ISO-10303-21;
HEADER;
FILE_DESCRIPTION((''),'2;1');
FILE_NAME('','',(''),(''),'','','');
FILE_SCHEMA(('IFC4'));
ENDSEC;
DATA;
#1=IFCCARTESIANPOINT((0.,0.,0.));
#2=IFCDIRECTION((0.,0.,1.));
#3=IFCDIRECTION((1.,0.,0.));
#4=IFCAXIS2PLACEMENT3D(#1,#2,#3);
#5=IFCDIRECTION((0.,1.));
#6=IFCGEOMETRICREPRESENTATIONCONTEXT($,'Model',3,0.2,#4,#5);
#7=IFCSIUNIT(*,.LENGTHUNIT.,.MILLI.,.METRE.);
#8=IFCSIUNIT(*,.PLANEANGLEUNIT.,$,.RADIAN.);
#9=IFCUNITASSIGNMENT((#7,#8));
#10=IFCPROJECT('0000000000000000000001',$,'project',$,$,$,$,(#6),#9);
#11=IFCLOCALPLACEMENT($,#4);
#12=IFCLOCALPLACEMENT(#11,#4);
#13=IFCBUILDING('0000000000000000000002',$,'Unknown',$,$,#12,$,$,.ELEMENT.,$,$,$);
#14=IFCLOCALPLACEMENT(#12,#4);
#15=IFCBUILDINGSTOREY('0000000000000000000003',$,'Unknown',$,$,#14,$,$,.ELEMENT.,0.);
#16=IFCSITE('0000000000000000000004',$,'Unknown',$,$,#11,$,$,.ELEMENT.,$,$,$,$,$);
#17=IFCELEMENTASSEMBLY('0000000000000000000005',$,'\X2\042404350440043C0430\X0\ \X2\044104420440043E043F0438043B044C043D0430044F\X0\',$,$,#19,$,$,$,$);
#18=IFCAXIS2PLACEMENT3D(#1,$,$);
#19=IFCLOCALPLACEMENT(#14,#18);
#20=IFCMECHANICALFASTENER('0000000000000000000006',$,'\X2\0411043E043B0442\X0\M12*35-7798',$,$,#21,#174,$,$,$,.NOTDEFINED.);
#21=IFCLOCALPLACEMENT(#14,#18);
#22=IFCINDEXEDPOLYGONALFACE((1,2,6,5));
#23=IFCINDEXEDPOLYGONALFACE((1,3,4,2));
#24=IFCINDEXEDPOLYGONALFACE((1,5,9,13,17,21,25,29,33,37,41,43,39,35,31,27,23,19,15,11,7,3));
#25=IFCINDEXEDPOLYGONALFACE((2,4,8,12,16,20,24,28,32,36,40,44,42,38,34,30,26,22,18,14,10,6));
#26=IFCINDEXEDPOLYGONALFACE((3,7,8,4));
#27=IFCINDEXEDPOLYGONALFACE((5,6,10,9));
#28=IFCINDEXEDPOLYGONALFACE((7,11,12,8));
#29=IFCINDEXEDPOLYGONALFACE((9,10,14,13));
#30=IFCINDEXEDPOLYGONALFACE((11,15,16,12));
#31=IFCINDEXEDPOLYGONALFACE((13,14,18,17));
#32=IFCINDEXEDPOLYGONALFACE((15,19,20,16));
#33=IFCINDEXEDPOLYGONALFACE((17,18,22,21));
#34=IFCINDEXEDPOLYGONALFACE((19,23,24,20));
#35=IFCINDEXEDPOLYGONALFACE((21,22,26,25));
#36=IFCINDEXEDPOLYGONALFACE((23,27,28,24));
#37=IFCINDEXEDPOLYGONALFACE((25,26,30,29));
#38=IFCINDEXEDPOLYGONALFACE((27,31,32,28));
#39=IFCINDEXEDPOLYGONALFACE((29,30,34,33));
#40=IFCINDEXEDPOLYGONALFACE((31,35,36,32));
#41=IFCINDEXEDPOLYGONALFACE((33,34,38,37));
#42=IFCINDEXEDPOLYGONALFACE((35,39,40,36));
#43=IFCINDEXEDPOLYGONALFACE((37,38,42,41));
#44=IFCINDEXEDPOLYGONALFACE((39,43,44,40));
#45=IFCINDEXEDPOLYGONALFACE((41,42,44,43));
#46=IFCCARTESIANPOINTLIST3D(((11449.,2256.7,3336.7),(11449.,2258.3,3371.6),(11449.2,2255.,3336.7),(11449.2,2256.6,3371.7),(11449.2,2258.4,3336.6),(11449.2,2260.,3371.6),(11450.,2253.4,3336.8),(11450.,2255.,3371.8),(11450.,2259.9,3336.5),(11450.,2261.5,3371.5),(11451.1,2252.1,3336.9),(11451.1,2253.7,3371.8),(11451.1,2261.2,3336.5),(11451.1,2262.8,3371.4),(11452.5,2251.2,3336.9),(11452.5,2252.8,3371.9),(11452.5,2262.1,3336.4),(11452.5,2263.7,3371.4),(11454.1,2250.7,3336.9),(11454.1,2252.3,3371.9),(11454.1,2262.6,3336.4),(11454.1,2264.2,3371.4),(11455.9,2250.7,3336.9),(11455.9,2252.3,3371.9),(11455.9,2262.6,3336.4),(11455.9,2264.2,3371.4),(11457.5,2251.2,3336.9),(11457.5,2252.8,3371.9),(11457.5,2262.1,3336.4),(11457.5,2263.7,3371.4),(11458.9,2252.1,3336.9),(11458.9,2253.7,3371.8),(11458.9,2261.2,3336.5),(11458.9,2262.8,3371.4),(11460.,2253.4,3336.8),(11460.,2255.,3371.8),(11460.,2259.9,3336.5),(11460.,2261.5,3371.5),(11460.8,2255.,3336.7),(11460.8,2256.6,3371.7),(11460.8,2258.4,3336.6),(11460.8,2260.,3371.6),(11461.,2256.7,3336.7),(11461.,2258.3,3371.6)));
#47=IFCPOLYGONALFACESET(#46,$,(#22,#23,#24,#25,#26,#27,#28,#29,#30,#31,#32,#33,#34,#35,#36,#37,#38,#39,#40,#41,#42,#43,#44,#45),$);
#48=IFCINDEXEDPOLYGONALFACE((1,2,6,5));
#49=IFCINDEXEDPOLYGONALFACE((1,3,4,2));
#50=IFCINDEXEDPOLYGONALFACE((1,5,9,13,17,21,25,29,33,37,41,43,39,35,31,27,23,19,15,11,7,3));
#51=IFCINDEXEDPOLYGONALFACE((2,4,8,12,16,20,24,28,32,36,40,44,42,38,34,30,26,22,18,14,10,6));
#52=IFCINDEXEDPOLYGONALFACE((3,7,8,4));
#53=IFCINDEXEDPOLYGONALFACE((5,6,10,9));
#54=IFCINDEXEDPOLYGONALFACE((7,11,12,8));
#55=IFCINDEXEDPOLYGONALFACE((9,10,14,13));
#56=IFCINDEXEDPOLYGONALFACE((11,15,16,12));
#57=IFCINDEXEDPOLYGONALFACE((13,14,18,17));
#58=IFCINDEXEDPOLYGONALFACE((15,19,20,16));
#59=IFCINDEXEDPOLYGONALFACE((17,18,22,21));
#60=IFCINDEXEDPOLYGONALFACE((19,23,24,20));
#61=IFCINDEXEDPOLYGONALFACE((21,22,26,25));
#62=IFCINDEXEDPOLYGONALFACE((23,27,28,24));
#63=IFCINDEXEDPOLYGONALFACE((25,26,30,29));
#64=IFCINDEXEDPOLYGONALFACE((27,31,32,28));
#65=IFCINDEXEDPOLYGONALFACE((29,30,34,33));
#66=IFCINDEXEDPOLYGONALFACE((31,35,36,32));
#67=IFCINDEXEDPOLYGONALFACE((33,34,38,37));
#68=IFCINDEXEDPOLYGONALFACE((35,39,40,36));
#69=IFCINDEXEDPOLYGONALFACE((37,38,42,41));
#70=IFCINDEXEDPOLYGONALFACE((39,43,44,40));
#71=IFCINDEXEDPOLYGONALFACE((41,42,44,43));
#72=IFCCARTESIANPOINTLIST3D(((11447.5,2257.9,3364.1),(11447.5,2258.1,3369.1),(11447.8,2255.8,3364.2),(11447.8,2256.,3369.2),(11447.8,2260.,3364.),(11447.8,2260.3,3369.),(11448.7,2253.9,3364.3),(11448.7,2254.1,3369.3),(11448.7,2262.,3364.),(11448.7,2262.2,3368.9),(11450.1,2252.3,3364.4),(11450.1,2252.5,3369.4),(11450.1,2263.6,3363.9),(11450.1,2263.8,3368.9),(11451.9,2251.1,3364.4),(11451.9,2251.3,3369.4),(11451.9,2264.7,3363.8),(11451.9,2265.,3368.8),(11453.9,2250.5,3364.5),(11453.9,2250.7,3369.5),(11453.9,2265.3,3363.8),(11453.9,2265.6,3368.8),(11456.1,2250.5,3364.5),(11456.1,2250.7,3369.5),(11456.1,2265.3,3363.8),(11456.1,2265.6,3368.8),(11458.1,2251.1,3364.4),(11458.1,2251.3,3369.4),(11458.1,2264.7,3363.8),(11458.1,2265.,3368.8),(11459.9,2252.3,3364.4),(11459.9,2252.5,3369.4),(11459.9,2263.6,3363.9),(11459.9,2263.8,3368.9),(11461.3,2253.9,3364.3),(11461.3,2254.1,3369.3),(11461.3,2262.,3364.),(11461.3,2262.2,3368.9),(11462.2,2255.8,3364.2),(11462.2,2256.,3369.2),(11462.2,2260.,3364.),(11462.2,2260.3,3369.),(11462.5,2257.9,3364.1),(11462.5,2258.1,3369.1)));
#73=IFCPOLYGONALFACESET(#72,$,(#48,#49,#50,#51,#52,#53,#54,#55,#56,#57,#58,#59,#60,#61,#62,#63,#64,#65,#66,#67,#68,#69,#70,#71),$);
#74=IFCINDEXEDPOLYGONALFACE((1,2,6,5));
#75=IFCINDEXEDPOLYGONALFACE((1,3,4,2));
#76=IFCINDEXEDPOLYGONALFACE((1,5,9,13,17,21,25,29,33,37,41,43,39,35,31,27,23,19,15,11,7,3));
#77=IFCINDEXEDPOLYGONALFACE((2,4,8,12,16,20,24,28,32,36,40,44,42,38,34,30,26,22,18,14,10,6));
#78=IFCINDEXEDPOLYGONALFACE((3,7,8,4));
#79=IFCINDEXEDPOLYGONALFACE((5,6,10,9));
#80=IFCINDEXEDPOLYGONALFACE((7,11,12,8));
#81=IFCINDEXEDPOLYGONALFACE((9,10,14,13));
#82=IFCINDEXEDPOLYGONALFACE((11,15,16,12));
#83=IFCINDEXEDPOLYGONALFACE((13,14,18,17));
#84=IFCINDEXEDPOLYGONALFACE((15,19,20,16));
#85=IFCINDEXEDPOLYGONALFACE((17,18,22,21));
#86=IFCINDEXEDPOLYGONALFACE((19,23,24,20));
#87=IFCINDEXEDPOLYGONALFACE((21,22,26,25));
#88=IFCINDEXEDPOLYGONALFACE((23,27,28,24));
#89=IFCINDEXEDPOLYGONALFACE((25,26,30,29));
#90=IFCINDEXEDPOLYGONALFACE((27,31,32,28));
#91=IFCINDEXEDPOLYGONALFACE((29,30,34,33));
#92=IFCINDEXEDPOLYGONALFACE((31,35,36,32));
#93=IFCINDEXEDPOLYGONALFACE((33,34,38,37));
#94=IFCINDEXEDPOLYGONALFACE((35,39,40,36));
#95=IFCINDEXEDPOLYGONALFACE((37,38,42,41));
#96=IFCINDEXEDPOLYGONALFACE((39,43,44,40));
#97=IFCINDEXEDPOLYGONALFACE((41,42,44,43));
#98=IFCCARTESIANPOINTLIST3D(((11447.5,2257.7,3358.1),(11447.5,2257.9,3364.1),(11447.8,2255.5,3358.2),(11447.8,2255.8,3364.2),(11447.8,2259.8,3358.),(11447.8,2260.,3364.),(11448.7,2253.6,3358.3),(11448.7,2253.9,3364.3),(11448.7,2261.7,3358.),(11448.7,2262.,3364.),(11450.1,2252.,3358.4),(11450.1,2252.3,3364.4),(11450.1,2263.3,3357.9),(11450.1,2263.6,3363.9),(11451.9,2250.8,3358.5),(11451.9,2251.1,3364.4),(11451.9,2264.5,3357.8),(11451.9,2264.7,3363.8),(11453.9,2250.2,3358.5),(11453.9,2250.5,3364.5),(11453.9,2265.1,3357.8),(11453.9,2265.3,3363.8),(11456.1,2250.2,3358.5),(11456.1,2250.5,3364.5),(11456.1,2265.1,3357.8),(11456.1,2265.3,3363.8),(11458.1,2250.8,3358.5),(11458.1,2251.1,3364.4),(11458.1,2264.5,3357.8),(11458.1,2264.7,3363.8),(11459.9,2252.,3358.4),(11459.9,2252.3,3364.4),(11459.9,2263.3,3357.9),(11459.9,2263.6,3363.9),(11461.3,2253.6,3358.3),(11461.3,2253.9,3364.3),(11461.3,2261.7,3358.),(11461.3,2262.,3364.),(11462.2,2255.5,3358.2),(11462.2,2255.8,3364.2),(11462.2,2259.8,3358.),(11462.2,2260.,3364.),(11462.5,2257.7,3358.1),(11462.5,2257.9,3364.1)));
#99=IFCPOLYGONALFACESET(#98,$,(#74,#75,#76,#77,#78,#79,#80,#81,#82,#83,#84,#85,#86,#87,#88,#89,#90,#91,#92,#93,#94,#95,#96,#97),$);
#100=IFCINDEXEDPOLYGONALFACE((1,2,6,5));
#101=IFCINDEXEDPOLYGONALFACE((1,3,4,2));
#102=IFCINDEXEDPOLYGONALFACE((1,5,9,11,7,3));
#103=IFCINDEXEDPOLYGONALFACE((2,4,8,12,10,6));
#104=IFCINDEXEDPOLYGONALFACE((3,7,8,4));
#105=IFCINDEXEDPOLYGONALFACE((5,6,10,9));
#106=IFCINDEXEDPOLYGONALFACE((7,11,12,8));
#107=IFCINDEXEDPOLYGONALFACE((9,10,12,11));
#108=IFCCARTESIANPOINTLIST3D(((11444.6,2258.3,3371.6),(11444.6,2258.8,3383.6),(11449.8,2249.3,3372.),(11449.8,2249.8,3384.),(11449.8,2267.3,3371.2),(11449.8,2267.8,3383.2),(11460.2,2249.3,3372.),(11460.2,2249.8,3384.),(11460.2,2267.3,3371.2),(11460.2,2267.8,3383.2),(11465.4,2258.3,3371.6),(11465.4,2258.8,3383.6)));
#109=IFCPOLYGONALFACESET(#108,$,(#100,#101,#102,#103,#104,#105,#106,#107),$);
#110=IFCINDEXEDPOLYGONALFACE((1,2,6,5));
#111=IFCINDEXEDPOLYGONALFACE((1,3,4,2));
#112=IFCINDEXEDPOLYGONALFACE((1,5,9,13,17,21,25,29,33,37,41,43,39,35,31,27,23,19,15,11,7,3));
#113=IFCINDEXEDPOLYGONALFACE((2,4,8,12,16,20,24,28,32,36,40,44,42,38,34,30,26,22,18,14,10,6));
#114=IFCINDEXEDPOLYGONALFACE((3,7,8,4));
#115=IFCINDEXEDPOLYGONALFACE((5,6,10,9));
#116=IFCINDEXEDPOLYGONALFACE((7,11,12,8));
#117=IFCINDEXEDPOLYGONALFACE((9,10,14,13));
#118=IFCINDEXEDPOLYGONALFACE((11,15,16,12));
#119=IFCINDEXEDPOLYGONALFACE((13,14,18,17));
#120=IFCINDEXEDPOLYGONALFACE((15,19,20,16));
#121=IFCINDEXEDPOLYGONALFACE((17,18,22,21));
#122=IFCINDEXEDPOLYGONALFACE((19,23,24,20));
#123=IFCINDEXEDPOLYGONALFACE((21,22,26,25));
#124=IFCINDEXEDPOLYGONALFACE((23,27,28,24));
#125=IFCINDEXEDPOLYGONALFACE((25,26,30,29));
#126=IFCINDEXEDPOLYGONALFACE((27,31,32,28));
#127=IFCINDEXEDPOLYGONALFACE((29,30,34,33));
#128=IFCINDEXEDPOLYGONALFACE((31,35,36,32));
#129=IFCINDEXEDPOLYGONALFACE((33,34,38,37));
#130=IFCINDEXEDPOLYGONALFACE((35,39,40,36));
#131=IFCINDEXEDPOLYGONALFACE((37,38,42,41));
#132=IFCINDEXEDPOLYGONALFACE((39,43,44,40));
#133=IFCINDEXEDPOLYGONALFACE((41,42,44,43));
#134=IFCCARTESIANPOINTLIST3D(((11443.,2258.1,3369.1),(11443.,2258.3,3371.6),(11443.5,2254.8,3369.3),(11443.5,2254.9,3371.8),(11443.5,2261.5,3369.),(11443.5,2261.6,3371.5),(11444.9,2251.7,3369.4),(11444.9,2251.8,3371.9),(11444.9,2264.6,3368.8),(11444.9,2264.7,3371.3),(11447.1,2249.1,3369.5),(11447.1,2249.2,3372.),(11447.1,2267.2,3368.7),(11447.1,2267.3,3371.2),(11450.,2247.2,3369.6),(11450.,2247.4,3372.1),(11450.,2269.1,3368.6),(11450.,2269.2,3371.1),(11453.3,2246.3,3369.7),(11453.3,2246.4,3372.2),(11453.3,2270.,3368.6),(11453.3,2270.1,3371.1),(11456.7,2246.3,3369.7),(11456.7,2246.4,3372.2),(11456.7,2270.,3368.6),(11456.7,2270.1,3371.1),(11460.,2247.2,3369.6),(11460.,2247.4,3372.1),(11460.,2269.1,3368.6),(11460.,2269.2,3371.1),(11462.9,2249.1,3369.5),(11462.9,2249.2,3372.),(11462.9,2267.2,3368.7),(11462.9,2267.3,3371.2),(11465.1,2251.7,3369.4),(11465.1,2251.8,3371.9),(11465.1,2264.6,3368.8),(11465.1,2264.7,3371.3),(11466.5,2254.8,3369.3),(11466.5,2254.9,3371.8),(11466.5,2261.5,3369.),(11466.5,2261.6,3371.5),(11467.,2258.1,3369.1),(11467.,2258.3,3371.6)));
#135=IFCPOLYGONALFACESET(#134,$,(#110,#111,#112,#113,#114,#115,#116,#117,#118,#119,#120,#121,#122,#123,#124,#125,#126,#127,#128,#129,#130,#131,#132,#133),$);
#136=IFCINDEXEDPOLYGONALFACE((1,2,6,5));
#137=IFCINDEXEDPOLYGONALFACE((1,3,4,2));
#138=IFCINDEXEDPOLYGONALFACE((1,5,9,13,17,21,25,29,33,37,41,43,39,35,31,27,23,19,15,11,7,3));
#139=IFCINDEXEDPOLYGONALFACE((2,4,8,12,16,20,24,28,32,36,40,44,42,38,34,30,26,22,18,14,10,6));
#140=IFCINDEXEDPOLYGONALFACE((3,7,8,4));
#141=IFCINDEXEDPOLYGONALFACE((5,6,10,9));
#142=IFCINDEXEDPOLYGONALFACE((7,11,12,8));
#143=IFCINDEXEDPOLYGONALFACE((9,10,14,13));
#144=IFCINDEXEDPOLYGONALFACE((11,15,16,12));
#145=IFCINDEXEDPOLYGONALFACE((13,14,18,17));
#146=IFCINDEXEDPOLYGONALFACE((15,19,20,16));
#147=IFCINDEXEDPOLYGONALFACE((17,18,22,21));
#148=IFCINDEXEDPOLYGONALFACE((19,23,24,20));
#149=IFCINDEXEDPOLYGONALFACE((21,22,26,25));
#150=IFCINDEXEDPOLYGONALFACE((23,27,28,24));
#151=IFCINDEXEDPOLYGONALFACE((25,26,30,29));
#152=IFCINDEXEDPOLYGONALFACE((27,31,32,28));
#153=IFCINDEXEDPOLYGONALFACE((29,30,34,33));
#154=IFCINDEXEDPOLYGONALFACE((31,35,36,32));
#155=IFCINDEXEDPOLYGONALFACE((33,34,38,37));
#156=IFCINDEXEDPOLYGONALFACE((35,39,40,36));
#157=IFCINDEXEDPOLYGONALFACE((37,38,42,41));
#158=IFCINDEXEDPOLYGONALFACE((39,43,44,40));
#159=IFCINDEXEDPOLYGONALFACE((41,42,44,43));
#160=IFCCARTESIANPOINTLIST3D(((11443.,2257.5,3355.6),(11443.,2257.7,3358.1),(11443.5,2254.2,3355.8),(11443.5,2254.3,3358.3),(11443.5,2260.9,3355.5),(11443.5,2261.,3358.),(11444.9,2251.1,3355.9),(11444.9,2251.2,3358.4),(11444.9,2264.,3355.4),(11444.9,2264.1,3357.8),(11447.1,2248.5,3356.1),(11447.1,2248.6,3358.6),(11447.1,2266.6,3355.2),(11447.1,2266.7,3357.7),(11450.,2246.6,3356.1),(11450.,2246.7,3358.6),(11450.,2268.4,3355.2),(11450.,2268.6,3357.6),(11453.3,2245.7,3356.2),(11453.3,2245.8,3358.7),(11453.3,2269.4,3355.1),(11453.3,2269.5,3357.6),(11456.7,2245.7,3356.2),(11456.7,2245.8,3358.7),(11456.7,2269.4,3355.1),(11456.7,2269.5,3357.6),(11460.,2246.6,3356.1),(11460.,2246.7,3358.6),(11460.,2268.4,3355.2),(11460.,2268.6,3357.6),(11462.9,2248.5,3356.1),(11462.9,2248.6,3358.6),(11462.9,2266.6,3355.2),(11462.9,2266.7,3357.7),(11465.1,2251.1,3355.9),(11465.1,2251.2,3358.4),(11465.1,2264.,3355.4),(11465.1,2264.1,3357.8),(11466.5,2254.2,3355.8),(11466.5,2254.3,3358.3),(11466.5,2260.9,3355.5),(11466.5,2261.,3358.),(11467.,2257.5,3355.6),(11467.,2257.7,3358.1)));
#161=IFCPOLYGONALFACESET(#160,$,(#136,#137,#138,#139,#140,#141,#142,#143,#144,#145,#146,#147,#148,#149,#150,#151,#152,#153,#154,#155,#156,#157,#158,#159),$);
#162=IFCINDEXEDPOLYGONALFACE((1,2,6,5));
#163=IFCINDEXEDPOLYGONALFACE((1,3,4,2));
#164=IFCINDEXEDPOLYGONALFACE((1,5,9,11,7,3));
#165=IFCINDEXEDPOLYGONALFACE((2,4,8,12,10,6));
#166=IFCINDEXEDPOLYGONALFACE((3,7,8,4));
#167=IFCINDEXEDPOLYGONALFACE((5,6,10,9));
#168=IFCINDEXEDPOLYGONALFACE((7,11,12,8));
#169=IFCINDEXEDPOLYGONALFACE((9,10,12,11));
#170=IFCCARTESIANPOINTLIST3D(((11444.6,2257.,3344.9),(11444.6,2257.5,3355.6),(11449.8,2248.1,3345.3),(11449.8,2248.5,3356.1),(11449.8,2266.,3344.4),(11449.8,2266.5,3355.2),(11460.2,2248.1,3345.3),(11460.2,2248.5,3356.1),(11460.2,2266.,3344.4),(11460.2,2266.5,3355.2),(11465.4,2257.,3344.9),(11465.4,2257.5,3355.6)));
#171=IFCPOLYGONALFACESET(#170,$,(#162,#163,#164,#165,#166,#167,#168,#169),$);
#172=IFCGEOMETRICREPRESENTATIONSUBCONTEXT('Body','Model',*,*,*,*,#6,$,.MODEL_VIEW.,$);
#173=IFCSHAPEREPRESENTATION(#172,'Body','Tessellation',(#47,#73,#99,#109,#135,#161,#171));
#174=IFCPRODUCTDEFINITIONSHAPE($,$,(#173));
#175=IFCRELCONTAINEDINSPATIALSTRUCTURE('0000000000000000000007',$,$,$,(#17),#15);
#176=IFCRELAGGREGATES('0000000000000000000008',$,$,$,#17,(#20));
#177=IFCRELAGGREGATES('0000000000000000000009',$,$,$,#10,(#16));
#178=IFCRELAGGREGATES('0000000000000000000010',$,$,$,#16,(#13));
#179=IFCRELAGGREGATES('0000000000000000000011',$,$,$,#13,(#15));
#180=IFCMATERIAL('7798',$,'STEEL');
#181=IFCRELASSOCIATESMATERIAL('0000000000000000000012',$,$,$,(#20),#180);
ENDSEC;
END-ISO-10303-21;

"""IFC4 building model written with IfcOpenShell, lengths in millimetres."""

from ifc_helpers import new_model, si_unit, direction, frame, origin_with_axes, place, context, subcontext, project, spatial, line, arc, indexed_curve, outline, extrude, source, transform, mapped, material, element, aggregate, save


model = new_model("IFC4")

# Units and contexts
model_context = context("Model", 3, precision=0.2, world=origin_with_axes(), true_north=direction((0.0, 1.0)))
body_context = subcontext(model_context, "Body", "Model", "MODEL_VIEW")
ifc_project = project(units=[si_unit("LENGTHUNIT", "METRE", prefix="MILLI"), si_unit("PLANEANGLEUNIT", "RADIAN")], contexts=[model_context])

# Site, building, storey
site_placement = place(None, origin_with_axes())
site = spatial("IfcSite", under=ifc_project, at=site_placement, Name="Unknown", CompositionType="ELEMENT")
building_placement = place(site_placement, origin_with_axes())
building = spatial("IfcBuilding", under=site, at=building_placement, Name="Unknown", CompositionType="ELEMENT")
storey_placement = place(building_placement, origin_with_axes())
storey = spatial("IfcBuildingStorey", under=building, at=storey_placement, Name="Unknown", CompositionType="ELEMENT", Elevation=0.0)

# Element assembly
assembly_1_placement = place(storey_placement, frame((11400.0, 88.6, 3426.7), z_axis=(1.0, 0.0, 0.0), x_axis=(0.0, 0.998969, -0.045408)))
assembly_1 = element("IfcElementAssembly", 1, at=assembly_1_placement, inside=storey, Name="Ферма стропильная")

# Mechanical fastener
ifc_material_1 = material(Name="7798", Category="STEEL")
shared_shape_1 = source(origin_with_axes(), body_context, "Body", "SweptSolid", [
    extrude(outline(indexed_curve([(6.0, 0.0), (0.0, 6.0), (-6.0, 0.0), (0.0, -6.0)], segments=[arc(1, 2, 3), arc(3, 4, 1)])), frame((0.0, 0.0, 7.5), z_axis=(0.0, 0.0, -1.0), x_axis=(0.0, 1.0, 0.0)), (0.0, 0.0, 1.0), 35.0),
    extrude(outline(indexed_curve([(7.5, 0.0), (0.0, 7.5), (-7.5, 0.0), (0.0, -7.5)], segments=[arc(1, 2, 3), arc(3, 4, 1)])), frame((0.0, 0.0, 5.0), z_axis=(0.0, 0.0, -1.0), x_axis=(0.0, 1.0, 0.0)), (0.0, 0.0, 1.0), 5.0),
    extrude(outline(indexed_curve([(7.5, 0.0), (0.0, 7.5), (-7.5, 0.0), (0.0, -7.5)], segments=[arc(1, 2, 3), arc(3, 4, 1)])), frame((0.0, 0.0, 0.0), z_axis=(0.0, 0.0, -1.0), x_axis=(0.0, 1.0, 0.0)), (0.0, 0.0, 1.0), 6.0),
    extrude(outline(indexed_curve([(10.4, 0.0), (5.2, 9.0), (-5.2, 9.0), (-10.4, 0.0), (-5.2, -9.0), (5.2, -9.0)], segments=[line(1, 2, 3, 4, 5, 6, 1)])), frame((0.0, 0.0, 19.5), z_axis=(0.0, 0.0, -1.0), x_axis=(0.0, 1.0, 0.0)), (0.0, 0.0, 1.0), 12.0),
    extrude(outline(indexed_curve([(12.0, 0.0), (0.0, 12.0), (-12.0, 0.0), (0.0, -12.0)], segments=[arc(1, 2, 3), arc(3, 4, 1)])), frame((0.0, 0.0, 7.5), z_axis=(0.0, 0.0, -1.0), x_axis=(0.0, 1.0, 0.0)), (0.0, 0.0, 1.0), 2.5),
    extrude(outline(indexed_curve([(12.0, 0.0), (0.0, 12.0), (-12.0, 0.0), (0.0, -12.0)], segments=[arc(1, 2, 3), arc(3, 4, 1)])), frame((0.0, 0.0, -6.0), z_axis=(0.0, 0.0, -1.0), x_axis=(0.0, 1.0, 0.0)), (0.0, 0.0, 1.0), 2.5),
    extrude(outline(indexed_curve([(10.4, 0.0), (5.2, 9.0), (-5.2, 9.0), (-10.4, 0.0), (-5.2, -9.0), (5.2, -9.0)], segments=[line(1, 2, 3, 4, 5, 6, 1)])), frame((0.0, 0.0, -8.5), z_axis=(0.0, 0.0, -1.0), x_axis=(0.0, 1.0, 0.0)), (0.0, 0.0, 1.0), 10.8),
])
mechanical_fastener_1_placement = place(assembly_1_placement, frame((2169.9, 36.0, 55.0), z_axis=(0.0, 1.0, 0.0), x_axis=(-1.0, 0.0, 0.0)))
mechanical_fastener_1 = element("IfcMechanicalFastener", 2, at=mechanical_fastener_1_placement, material=ifc_material_1, Name="БолтM12*35-7798", PredefinedType="NOTDEFINED", context=body_context, shape_type="MappedRepresentation", body=[
    mapped(shared_shape_1, transform((0.0, 0.0, 0.0))),
])
aggregate(assembly_1, [mechanical_fastener_1])

save(model, "model.ifc")
